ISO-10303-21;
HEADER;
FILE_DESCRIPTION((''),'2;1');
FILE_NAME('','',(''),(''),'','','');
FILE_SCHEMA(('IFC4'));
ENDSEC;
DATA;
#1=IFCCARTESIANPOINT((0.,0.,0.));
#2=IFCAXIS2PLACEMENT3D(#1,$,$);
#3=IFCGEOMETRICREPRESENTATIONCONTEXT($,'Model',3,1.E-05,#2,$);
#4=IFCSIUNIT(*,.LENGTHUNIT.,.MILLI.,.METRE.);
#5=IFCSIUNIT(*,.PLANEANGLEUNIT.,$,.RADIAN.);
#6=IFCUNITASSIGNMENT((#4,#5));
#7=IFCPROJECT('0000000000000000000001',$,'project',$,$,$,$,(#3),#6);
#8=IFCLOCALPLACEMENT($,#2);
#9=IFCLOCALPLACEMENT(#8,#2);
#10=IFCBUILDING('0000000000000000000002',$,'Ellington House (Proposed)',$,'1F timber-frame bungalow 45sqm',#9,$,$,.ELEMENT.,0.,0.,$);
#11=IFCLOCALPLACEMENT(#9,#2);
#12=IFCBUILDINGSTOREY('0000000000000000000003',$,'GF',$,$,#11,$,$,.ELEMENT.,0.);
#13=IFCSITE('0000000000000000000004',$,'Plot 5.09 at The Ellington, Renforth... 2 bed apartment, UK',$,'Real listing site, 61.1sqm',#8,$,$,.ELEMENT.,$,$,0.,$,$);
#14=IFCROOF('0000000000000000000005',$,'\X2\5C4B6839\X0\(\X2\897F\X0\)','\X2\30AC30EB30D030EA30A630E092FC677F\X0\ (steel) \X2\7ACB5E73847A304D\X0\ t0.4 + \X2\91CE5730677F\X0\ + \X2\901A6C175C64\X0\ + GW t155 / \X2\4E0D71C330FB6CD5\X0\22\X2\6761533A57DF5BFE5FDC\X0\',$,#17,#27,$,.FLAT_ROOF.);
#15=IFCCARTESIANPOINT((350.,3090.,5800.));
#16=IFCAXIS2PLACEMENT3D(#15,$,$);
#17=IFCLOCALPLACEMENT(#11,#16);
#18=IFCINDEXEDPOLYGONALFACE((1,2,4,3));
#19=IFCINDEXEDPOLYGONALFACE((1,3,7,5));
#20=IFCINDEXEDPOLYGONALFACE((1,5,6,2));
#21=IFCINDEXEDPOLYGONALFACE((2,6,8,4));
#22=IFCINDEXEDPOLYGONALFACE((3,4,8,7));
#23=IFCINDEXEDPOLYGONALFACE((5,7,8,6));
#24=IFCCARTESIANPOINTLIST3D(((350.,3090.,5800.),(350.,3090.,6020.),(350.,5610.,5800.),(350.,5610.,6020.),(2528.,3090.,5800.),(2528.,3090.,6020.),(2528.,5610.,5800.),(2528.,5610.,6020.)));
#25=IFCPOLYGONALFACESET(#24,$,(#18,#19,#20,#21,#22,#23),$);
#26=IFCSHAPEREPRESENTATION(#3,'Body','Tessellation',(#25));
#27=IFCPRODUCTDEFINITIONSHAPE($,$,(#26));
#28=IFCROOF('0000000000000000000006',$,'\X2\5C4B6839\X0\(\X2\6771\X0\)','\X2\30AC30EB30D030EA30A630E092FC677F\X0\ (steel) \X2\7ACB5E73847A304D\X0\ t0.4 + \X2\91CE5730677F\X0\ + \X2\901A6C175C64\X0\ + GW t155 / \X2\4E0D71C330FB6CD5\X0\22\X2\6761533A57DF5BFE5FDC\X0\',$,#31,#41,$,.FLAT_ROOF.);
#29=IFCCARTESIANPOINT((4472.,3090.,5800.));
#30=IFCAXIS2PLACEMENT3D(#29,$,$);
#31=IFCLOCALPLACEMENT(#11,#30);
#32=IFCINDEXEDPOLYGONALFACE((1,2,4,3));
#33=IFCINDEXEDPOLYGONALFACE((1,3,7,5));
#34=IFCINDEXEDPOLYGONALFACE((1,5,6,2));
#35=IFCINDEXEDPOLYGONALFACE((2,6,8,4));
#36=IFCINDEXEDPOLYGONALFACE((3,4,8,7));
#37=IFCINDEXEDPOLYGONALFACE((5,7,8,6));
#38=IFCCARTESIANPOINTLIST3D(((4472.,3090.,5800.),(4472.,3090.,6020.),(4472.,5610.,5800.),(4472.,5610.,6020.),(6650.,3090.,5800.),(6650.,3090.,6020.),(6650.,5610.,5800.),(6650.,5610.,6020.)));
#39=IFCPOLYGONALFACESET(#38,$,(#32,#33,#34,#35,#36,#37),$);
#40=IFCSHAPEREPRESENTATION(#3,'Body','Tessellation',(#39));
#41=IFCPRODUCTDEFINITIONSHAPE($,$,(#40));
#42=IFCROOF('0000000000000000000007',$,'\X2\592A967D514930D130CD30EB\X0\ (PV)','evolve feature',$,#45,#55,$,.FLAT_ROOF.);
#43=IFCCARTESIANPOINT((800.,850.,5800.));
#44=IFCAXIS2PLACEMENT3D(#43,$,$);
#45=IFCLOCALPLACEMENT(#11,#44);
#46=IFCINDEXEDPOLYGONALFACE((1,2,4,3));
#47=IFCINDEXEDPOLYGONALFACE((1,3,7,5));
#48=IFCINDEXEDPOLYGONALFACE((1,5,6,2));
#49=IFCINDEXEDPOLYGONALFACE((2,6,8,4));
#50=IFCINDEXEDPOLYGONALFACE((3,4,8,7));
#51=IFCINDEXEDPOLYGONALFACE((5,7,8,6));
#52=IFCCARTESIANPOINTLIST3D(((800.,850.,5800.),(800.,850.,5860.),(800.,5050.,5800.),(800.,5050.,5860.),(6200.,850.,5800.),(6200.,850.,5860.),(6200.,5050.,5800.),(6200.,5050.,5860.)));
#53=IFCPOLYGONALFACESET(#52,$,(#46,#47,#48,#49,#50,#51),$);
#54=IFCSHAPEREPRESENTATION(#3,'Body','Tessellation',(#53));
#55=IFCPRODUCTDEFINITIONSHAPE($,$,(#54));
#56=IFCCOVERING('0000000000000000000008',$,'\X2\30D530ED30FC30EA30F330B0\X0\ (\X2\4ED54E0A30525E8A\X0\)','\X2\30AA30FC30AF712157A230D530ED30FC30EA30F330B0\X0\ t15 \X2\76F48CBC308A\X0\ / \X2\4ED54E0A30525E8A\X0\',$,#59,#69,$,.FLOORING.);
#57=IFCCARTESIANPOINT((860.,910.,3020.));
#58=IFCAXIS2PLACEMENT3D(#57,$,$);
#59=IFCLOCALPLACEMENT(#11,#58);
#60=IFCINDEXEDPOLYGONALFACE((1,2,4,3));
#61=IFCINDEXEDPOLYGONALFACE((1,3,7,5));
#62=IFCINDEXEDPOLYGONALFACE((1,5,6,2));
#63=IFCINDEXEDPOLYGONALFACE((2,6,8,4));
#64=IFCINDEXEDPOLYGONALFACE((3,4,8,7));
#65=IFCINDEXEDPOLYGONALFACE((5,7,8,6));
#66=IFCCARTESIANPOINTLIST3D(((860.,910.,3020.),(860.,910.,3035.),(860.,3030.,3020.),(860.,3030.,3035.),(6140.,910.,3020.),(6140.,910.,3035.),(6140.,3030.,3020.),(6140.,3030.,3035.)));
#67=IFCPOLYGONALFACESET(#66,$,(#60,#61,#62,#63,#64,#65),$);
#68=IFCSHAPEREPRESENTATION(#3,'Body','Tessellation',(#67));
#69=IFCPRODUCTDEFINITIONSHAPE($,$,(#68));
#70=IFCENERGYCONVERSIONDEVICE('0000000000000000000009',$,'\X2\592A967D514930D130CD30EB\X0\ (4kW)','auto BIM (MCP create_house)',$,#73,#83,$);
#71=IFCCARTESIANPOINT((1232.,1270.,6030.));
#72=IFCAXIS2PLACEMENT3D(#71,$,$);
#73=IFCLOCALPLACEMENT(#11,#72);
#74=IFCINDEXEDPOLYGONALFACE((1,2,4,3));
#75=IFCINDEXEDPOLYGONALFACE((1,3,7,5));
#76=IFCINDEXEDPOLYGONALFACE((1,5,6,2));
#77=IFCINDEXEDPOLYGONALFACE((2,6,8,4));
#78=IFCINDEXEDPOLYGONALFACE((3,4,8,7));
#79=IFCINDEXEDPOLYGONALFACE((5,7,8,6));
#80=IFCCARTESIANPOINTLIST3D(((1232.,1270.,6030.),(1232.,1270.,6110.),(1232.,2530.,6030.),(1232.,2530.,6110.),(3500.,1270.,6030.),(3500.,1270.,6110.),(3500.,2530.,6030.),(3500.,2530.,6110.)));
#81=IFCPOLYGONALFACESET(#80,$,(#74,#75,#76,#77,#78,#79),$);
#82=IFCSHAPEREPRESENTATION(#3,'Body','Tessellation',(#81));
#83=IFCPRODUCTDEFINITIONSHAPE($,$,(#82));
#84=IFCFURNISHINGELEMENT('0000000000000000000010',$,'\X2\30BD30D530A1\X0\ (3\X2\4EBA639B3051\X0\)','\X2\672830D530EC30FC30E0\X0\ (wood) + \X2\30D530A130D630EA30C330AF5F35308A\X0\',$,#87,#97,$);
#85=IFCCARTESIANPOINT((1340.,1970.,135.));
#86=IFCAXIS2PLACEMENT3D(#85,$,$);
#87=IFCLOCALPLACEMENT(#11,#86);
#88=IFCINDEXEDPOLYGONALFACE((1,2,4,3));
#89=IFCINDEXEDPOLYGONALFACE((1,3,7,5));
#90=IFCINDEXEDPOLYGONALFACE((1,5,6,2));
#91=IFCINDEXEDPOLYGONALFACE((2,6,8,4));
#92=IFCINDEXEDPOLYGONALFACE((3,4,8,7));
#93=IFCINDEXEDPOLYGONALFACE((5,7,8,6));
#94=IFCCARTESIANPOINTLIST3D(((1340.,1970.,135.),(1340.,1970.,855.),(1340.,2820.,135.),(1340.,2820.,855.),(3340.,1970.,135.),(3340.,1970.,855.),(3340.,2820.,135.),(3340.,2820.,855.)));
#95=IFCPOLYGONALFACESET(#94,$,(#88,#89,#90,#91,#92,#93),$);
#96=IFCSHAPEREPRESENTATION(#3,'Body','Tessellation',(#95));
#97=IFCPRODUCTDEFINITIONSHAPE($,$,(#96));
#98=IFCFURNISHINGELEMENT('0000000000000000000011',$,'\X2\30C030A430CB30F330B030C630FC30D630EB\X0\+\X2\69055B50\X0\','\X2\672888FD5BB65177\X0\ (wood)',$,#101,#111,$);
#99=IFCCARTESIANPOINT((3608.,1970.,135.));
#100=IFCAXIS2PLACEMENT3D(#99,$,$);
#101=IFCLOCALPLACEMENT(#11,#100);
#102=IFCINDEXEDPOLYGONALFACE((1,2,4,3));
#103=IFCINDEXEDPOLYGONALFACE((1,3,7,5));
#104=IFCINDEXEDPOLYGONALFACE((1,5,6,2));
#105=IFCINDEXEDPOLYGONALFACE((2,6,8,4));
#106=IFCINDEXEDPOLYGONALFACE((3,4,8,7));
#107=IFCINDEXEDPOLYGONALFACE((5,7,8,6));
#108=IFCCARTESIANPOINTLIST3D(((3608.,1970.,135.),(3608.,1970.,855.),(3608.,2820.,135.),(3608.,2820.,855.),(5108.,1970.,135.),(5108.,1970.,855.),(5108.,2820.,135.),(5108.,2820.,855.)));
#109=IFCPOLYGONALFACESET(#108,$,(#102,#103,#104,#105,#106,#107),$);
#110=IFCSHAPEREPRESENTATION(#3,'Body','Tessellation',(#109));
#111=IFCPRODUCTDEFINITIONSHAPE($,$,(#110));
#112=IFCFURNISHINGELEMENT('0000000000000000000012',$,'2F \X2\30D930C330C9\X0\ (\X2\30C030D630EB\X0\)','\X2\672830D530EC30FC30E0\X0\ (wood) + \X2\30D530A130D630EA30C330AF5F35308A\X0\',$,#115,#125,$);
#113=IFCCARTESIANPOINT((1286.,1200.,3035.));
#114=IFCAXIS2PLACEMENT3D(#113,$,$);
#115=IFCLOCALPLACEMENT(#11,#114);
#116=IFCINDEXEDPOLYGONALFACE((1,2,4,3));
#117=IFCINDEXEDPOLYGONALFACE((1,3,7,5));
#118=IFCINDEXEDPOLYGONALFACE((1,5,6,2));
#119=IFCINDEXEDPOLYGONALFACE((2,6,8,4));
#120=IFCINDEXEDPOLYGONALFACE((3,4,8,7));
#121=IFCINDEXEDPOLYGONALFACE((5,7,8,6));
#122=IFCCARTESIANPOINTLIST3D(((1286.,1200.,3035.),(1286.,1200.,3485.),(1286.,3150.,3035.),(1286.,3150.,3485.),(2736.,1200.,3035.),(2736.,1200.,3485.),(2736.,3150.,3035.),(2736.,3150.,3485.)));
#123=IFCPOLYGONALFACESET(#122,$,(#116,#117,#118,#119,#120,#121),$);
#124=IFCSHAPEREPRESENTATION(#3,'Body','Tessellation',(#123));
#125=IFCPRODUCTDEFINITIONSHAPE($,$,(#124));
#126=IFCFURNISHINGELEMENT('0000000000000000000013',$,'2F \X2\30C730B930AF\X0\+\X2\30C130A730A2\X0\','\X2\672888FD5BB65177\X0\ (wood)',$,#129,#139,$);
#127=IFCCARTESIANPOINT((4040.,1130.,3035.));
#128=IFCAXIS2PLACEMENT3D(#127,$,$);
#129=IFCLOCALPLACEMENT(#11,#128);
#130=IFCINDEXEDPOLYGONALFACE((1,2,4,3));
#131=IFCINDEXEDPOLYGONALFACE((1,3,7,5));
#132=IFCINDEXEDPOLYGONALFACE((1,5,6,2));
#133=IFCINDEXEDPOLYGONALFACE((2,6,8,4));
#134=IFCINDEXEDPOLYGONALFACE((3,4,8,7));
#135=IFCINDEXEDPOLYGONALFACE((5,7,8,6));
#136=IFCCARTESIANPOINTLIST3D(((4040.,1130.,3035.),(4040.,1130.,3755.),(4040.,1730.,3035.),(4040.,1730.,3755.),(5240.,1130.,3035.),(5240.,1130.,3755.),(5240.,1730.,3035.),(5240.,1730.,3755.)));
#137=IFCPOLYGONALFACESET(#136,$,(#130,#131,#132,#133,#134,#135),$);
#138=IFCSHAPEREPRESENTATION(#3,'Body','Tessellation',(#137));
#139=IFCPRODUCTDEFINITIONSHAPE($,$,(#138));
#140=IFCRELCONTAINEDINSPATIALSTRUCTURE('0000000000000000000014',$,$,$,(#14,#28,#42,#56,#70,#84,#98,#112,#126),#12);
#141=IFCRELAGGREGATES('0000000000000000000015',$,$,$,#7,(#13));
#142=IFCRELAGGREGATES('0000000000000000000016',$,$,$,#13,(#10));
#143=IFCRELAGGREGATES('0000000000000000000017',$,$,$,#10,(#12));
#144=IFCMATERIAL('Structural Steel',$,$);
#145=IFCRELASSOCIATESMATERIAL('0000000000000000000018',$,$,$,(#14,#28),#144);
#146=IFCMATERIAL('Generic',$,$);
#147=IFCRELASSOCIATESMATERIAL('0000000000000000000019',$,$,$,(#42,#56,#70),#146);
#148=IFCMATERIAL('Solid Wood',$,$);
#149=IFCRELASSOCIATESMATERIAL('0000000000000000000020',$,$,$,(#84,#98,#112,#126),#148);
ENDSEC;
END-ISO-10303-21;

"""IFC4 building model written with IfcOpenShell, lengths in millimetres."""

from ifc_helpers import new_model, si_unit, frame, frame_2d, origin, place, context, project, spatial, rectangle, extrude, material, element, save


model = new_model("IFC4")

# Units and contexts
model_context = context("Model", 3, precision=1e-05, world=origin())
ifc_project = project(units=[si_unit("LENGTHUNIT", "METRE", prefix="MILLI"), si_unit("PLANEANGLEUNIT", "RADIAN")], contexts=[model_context])

# Site, building, storey
site_placement = place(None, origin())
site = spatial("IfcSite", under=ifc_project, at=site_placement, Name="Plot 5.09 at The Ellington, Renforth... 2 bed apartment, UK", ObjectType="Real listing site, 61.1sqm", CompositionType="ELEMENT", RefElevation=0.0)
building_placement = place(site_placement, origin())
building = spatial("IfcBuilding", under=site, at=building_placement, Name="Ellington House (Proposed)", ObjectType="1F timber-frame bungalow 45sqm", CompositionType="ELEMENT", ElevationOfRefHeight=0.0, ElevationOfTerrain=0.0)
storey_placement = place(building_placement, origin())
storey = spatial("IfcBuildingStorey", under=building, at=storey_placement, Name="GF", CompositionType="ELEMENT", Elevation=0.0)

# Shared definitions
ifc_material_1 = material(Name="Solid Wood")

# Shared definitions
ifc_material_2 = material(Name="Generic")

# Roofs
ifc_material_3 = material(Name="Structural Steel")
roof_1_placement = place(storey_placement, frame((350.0, 3090.0, 5800.0)))
element("IfcRoof", 1, at=roof_1_placement, inside=storey, material=ifc_material_3, Name="屋根(西)", Description="ガルバリウム鋼板 (steel) 立平葺き t0.4 + 野地板 + 通気層 + GW t155 / 不燃・法22条区域対応", PredefinedType="FLAT_ROOF", context=model_context, shape_type="SweptSolid", body=[
    extrude(rectangle(XDim=2178.0, YDim=2520.0, at=frame_2d((1089.0, 1260.0))), frame((350.0, 3090.0, 5800.0)), (0.0, 0.0, 1.0), 220.0),
])
roof_2_placement = place(storey_placement, frame((4472.0, 3090.0, 5800.0)))
element("IfcRoof", 2, at=roof_2_placement, inside=storey, material=ifc_material_3, Name="屋根(東)", Description="ガルバリウム鋼板 (steel) 立平葺き t0.4 + 野地板 + 通気層 + GW t155 / 不燃・法22条区域対応", PredefinedType="FLAT_ROOF", context=model_context, shape_type="SweptSolid", body=[
    extrude(rectangle(XDim=2178.0, YDim=2520.0, at=frame_2d((1089.0, 1260.0))), frame((4472.0, 3090.0, 5800.0)), (0.0, 0.0, 1.0), 220.0),
])
roof_3_placement = place(storey_placement, frame((800.0, 850.0, 5800.0)))
element("IfcRoof", 3, at=roof_3_placement, inside=storey, material=ifc_material_2, Name="太陽光パネル (PV)", Description="evolve feature", PredefinedType="FLAT_ROOF", context=model_context, shape_type="SweptSolid", body=[
    extrude(rectangle(XDim=5400.0, YDim=4200.0, at=frame_2d((2700.0, 2100.0))), frame((800.0, 850.0, 5800.0)), (0.0, 0.0, 1.0), 60.0),
])

# Covering
covering_placement = place(storey_placement, frame((860.0, 910.0, 3020.0)))
element("IfcCovering", 4, at=covering_placement, inside=storey, material=ifc_material_2, Name="フローリング (仕上げ床)", Description="オーク無垢フローリング t15 直貼り / 仕上げ床", PredefinedType="FLOORING", context=model_context, shape_type="SweptSolid", body=[
    extrude(rectangle(XDim=5280.0, YDim=2120.0, at=frame_2d((2640.0, 1060.0))), frame((860.0, 910.0, 3020.0)), (0.0, 0.0, 1.0), 15.0),
])

# Energy conversion device
energy_conversion_device_placement = place(storey_placement, frame((1232.0, 1270.0, 6030.0)))
element("IfcEnergyConversionDevice", 5, at=energy_conversion_device_placement, inside=storey, material=ifc_material_2, Name="太陽光パネル (4kW)", Description="auto BIM (MCP create_house)", context=model_context, shape_type="SweptSolid", body=[
    extrude(rectangle(XDim=2268.0, YDim=1260.0, at=frame_2d((1134.0, 630.0))), frame((1232.0, 1270.0, 6030.0)), (0.0, 0.0, 1.0), 80.0),
])

# Furnishing elements
furnishing_1_placement = place(storey_placement, frame((1340.0, 1970.0, 135.0)))
element("IfcFurnishingElement", 6, at=furnishing_1_placement, inside=storey, material=ifc_material_1, Name="ソファ (3人掛け)", Description="木フレーム (wood) + ファブリック張り", context=model_context, shape_type="SweptSolid", body=[
    extrude(rectangle(XDim=2000.0, YDim=850.0, at=frame_2d((1000.0, 425.0))), frame((1340.0, 1970.0, 135.0)), (0.0, 0.0, 1.0), 720.0),
])
furnishing_2_placement = place(storey_placement, frame((3608.0, 1970.0, 135.0)))
element("IfcFurnishingElement", 7, at=furnishing_2_placement, inside=storey, material=ifc_material_1, Name="ダイニングテーブル+椅子", Description="木製家具 (wood)", context=model_context, shape_type="SweptSolid", body=[
    extrude(rectangle(XDim=1500.0, YDim=850.0, at=frame_2d((750.0, 425.0))), frame((3608.0, 1970.0, 135.0)), (0.0, 0.0, 1.0), 720.0),
])
furnishing_3_placement = place(storey_placement, frame((1286.0, 1200.0, 3035.0)))
element("IfcFurnishingElement", 8, at=furnishing_3_placement, inside=storey, material=ifc_material_1, Name="2F ベッド (ダブル)", Description="木フレーム (wood) + ファブリック張り", context=model_context, shape_type="SweptSolid", body=[
    extrude(rectangle(XDim=1450.0, YDim=1950.0, at=frame_2d((725.0, 975.0))), frame((1286.0, 1200.0, 3035.0)), (0.0, 0.0, 1.0), 450.0),
])
furnishing_4_placement = place(storey_placement, frame((4040.0, 1130.0, 3035.0)))
element("IfcFurnishingElement", 9, at=furnishing_4_placement, inside=storey, material=ifc_material_1, Name="2F デスク+チェア", Description="木製家具 (wood)", context=model_context, shape_type="SweptSolid", body=[
    extrude(rectangle(XDim=1200.0, YDim=600.0, at=frame_2d((600.0, 300.0))), frame((4040.0, 1130.0, 3035.0)), (0.0, 0.0, 1.0), 720.0),
])

save(model, "model.ifc")
